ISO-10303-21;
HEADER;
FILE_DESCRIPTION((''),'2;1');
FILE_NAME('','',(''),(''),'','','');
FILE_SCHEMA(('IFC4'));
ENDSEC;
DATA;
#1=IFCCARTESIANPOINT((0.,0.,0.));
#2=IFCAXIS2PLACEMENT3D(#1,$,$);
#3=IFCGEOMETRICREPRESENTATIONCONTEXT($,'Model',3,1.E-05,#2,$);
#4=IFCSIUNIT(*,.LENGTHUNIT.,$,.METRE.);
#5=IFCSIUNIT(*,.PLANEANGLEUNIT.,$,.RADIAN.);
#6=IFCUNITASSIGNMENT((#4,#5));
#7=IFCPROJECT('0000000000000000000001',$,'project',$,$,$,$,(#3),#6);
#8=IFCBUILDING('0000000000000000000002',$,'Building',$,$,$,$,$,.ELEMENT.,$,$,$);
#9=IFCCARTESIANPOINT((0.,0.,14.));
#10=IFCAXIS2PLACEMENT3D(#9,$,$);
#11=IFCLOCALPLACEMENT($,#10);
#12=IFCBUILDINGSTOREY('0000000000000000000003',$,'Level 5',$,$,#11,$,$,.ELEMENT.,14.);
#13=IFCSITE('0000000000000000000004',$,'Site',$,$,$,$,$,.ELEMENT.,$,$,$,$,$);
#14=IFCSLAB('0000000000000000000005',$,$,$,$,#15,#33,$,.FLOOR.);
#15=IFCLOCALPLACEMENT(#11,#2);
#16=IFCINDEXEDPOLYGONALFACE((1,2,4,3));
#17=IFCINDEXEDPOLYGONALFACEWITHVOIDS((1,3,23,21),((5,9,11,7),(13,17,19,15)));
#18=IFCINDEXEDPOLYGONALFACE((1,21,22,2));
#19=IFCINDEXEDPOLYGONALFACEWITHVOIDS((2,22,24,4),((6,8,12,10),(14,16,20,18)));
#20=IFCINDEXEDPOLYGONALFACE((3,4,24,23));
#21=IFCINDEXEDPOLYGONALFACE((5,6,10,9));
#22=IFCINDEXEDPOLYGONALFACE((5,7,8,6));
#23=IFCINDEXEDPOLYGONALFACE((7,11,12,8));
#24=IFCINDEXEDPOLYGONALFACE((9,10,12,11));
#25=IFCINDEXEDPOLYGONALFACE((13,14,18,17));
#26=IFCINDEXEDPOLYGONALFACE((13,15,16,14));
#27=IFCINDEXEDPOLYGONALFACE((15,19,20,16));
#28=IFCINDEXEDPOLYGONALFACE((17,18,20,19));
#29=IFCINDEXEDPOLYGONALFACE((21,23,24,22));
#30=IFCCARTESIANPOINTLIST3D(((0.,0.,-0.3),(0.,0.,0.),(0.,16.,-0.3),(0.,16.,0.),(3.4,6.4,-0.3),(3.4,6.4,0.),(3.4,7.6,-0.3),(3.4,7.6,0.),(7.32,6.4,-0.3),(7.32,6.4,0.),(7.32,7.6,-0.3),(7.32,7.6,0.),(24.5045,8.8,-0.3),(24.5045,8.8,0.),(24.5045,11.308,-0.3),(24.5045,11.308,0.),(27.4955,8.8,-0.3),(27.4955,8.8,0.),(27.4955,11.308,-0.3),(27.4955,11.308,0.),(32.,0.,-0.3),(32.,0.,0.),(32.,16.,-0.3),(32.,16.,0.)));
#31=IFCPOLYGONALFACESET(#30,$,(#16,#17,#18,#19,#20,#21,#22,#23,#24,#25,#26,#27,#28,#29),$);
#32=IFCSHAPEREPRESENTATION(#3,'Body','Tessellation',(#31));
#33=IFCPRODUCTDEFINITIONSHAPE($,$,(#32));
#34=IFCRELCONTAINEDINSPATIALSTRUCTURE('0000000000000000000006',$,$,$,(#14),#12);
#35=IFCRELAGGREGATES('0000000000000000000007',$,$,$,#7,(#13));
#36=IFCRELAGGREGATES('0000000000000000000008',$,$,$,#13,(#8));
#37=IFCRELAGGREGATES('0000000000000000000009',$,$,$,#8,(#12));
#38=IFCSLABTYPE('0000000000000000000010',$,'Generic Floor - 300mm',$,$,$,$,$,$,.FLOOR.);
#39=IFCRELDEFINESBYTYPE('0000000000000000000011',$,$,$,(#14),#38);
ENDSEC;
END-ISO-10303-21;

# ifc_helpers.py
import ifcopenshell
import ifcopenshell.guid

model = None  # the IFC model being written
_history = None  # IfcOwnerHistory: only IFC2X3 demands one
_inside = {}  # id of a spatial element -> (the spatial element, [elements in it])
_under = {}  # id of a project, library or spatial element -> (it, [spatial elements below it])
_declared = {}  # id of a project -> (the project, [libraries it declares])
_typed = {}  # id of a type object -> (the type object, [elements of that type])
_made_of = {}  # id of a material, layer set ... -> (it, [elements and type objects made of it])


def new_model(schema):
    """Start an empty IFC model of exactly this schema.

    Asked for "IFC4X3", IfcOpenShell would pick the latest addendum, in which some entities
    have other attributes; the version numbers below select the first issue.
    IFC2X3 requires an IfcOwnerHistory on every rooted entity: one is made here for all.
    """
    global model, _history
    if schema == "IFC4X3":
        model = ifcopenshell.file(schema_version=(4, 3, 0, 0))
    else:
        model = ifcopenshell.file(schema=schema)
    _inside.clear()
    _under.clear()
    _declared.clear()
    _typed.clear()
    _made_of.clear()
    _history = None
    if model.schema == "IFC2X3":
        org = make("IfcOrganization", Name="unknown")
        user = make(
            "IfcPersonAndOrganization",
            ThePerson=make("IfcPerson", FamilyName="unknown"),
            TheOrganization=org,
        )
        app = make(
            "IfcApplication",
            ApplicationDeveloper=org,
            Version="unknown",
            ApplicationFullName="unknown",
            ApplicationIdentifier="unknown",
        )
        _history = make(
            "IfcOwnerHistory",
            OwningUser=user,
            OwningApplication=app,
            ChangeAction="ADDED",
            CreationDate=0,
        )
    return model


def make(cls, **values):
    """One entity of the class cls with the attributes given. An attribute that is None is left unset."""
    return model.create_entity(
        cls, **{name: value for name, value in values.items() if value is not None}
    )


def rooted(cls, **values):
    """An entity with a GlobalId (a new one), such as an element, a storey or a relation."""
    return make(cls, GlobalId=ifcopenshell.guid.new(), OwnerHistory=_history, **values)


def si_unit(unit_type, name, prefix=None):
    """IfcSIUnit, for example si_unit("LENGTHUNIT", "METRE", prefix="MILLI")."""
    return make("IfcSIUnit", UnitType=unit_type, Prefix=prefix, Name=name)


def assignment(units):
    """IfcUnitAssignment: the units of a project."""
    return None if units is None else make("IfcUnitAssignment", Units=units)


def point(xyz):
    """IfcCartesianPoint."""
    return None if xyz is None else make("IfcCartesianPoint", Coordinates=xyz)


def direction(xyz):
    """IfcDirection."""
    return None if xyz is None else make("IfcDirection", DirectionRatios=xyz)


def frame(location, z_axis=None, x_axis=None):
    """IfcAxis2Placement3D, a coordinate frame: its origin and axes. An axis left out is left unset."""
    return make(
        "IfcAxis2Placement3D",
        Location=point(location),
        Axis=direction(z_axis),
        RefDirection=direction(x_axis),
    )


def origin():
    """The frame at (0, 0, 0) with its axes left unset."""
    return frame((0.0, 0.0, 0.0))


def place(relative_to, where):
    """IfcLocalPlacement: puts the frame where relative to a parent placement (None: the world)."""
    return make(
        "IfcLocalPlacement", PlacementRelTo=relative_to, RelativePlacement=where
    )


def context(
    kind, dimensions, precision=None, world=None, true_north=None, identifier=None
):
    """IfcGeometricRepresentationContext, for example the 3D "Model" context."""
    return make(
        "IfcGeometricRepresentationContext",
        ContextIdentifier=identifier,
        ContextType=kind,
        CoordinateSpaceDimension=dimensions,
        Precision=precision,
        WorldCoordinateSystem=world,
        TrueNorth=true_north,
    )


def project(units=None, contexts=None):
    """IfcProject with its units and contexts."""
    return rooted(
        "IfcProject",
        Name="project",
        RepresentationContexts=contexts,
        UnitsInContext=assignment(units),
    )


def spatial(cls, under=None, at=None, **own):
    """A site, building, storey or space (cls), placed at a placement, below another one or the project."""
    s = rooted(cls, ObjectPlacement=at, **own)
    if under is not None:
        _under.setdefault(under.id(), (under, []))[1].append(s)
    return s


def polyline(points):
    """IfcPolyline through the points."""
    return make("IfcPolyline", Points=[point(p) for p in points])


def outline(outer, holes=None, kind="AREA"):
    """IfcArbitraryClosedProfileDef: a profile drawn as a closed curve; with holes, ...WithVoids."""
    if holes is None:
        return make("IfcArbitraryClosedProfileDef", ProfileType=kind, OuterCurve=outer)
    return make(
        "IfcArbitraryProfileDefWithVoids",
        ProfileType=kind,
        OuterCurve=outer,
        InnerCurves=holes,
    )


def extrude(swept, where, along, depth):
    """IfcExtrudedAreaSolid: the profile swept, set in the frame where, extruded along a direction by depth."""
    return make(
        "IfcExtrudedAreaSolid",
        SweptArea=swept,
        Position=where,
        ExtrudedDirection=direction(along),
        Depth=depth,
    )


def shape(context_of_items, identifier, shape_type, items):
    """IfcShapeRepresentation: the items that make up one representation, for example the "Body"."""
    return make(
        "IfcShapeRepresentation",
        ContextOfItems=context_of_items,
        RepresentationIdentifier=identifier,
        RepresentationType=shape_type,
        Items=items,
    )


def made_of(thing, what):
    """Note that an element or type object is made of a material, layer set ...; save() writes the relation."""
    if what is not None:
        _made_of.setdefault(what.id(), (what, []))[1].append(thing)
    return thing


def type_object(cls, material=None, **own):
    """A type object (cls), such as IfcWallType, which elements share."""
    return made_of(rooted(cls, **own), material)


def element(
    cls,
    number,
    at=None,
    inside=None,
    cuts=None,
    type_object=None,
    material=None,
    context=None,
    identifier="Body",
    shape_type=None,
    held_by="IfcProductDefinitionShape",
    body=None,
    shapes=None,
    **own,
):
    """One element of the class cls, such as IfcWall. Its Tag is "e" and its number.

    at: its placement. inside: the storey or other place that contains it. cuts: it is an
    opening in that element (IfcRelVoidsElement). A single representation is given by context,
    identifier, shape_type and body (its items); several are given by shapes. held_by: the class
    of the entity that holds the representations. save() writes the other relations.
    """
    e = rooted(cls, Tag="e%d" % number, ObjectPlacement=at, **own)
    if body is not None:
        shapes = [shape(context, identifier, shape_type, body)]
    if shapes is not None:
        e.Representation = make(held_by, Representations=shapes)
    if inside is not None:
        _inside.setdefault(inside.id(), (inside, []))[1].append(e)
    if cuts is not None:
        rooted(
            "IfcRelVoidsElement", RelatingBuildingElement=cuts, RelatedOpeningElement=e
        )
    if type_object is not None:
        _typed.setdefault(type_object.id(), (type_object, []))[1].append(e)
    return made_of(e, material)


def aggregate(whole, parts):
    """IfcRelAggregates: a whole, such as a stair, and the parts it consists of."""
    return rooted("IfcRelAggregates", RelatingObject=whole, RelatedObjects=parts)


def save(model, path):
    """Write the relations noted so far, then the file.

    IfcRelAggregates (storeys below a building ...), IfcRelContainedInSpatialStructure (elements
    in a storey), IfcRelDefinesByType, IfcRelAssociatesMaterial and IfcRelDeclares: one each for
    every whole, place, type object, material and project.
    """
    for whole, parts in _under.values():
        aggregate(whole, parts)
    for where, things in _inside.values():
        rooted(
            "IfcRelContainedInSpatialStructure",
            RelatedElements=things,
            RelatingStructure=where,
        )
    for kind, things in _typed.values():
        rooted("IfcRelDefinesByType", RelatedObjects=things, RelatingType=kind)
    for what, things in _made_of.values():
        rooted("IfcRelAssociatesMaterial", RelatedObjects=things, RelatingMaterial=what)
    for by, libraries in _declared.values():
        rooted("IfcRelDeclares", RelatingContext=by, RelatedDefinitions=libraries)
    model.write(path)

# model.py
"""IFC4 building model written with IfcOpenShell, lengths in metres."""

from ifc_helpers import new_model, si_unit, frame, origin, place, context, project, spatial, polyline, outline, extrude, type_object, element, save


model = new_model("IFC4")

# Units and contexts
model_context = context("Model", 3, precision=1e-05, world=origin())
ifc_project = project(units=[si_unit("LENGTHUNIT", "METRE"), si_unit("PLANEANGLEUNIT", "RADIAN")], contexts=[model_context])

# Site, building, storey
site = spatial("IfcSite", under=ifc_project, Name="Site", CompositionType="ELEMENT")
building = spatial("IfcBuilding", under=site, Name="Building", CompositionType="ELEMENT")
storey_placement = place(None, frame((0.0, 0.0, 14.0)))
storey = spatial("IfcBuildingStorey", under=building, at=storey_placement, Name="Level 5", CompositionType="ELEMENT", Elevation=14.0)

# Slab, openings
slab_type = type_object("IfcSlabType", Name="Generic Floor - 300mm", PredefinedType="FLOOR")
slab_placement = place(None, frame((0.0, 0.0, 14.0)))
slab = element("IfcSlab", 1, at=slab_placement, inside=storey, type_object=slab_type, PredefinedType="FLOOR", context=model_context, shape_type="SweptSolid", body=[
    extrude(outline(polyline([(0.0, 0.0), (32.0, 0.0), (32.0, 16.0), (0.0, 16.0), (0.0, 0.0)])), origin(), (0.0, 0.0, -1.0), 0.3),
])
opening_1_placement = place(None, frame((0.0, 0.0, 14.001)))
element("IfcOpeningElement", 2, at=opening_1_placement, cuts=slab, PredefinedType="OPENING", context=model_context, shape_type="SweptSolid", body=[
    extrude(outline(polyline([(3.4, 7.6), (3.4, 6.4), (7.32, 6.4), (7.32, 7.6), (3.4, 7.6)])), origin(), (0.0, 0.0, -1.0), 0.302),
])
opening_2_placement = place(None, frame((0.0, 0.0, 14.001)))
element("IfcOpeningElement", 3, at=opening_2_placement, cuts=slab, PredefinedType="OPENING", context=model_context, shape_type="SweptSolid", body=[
    extrude(outline(polyline([(24.5045, 8.8), (27.4955, 8.8), (27.4955, 11.308), (24.5045, 11.308), (24.5045, 8.8)])), origin(), (0.0, 0.0, -1.0), 0.302),
])

save(model, "model.ifc")
